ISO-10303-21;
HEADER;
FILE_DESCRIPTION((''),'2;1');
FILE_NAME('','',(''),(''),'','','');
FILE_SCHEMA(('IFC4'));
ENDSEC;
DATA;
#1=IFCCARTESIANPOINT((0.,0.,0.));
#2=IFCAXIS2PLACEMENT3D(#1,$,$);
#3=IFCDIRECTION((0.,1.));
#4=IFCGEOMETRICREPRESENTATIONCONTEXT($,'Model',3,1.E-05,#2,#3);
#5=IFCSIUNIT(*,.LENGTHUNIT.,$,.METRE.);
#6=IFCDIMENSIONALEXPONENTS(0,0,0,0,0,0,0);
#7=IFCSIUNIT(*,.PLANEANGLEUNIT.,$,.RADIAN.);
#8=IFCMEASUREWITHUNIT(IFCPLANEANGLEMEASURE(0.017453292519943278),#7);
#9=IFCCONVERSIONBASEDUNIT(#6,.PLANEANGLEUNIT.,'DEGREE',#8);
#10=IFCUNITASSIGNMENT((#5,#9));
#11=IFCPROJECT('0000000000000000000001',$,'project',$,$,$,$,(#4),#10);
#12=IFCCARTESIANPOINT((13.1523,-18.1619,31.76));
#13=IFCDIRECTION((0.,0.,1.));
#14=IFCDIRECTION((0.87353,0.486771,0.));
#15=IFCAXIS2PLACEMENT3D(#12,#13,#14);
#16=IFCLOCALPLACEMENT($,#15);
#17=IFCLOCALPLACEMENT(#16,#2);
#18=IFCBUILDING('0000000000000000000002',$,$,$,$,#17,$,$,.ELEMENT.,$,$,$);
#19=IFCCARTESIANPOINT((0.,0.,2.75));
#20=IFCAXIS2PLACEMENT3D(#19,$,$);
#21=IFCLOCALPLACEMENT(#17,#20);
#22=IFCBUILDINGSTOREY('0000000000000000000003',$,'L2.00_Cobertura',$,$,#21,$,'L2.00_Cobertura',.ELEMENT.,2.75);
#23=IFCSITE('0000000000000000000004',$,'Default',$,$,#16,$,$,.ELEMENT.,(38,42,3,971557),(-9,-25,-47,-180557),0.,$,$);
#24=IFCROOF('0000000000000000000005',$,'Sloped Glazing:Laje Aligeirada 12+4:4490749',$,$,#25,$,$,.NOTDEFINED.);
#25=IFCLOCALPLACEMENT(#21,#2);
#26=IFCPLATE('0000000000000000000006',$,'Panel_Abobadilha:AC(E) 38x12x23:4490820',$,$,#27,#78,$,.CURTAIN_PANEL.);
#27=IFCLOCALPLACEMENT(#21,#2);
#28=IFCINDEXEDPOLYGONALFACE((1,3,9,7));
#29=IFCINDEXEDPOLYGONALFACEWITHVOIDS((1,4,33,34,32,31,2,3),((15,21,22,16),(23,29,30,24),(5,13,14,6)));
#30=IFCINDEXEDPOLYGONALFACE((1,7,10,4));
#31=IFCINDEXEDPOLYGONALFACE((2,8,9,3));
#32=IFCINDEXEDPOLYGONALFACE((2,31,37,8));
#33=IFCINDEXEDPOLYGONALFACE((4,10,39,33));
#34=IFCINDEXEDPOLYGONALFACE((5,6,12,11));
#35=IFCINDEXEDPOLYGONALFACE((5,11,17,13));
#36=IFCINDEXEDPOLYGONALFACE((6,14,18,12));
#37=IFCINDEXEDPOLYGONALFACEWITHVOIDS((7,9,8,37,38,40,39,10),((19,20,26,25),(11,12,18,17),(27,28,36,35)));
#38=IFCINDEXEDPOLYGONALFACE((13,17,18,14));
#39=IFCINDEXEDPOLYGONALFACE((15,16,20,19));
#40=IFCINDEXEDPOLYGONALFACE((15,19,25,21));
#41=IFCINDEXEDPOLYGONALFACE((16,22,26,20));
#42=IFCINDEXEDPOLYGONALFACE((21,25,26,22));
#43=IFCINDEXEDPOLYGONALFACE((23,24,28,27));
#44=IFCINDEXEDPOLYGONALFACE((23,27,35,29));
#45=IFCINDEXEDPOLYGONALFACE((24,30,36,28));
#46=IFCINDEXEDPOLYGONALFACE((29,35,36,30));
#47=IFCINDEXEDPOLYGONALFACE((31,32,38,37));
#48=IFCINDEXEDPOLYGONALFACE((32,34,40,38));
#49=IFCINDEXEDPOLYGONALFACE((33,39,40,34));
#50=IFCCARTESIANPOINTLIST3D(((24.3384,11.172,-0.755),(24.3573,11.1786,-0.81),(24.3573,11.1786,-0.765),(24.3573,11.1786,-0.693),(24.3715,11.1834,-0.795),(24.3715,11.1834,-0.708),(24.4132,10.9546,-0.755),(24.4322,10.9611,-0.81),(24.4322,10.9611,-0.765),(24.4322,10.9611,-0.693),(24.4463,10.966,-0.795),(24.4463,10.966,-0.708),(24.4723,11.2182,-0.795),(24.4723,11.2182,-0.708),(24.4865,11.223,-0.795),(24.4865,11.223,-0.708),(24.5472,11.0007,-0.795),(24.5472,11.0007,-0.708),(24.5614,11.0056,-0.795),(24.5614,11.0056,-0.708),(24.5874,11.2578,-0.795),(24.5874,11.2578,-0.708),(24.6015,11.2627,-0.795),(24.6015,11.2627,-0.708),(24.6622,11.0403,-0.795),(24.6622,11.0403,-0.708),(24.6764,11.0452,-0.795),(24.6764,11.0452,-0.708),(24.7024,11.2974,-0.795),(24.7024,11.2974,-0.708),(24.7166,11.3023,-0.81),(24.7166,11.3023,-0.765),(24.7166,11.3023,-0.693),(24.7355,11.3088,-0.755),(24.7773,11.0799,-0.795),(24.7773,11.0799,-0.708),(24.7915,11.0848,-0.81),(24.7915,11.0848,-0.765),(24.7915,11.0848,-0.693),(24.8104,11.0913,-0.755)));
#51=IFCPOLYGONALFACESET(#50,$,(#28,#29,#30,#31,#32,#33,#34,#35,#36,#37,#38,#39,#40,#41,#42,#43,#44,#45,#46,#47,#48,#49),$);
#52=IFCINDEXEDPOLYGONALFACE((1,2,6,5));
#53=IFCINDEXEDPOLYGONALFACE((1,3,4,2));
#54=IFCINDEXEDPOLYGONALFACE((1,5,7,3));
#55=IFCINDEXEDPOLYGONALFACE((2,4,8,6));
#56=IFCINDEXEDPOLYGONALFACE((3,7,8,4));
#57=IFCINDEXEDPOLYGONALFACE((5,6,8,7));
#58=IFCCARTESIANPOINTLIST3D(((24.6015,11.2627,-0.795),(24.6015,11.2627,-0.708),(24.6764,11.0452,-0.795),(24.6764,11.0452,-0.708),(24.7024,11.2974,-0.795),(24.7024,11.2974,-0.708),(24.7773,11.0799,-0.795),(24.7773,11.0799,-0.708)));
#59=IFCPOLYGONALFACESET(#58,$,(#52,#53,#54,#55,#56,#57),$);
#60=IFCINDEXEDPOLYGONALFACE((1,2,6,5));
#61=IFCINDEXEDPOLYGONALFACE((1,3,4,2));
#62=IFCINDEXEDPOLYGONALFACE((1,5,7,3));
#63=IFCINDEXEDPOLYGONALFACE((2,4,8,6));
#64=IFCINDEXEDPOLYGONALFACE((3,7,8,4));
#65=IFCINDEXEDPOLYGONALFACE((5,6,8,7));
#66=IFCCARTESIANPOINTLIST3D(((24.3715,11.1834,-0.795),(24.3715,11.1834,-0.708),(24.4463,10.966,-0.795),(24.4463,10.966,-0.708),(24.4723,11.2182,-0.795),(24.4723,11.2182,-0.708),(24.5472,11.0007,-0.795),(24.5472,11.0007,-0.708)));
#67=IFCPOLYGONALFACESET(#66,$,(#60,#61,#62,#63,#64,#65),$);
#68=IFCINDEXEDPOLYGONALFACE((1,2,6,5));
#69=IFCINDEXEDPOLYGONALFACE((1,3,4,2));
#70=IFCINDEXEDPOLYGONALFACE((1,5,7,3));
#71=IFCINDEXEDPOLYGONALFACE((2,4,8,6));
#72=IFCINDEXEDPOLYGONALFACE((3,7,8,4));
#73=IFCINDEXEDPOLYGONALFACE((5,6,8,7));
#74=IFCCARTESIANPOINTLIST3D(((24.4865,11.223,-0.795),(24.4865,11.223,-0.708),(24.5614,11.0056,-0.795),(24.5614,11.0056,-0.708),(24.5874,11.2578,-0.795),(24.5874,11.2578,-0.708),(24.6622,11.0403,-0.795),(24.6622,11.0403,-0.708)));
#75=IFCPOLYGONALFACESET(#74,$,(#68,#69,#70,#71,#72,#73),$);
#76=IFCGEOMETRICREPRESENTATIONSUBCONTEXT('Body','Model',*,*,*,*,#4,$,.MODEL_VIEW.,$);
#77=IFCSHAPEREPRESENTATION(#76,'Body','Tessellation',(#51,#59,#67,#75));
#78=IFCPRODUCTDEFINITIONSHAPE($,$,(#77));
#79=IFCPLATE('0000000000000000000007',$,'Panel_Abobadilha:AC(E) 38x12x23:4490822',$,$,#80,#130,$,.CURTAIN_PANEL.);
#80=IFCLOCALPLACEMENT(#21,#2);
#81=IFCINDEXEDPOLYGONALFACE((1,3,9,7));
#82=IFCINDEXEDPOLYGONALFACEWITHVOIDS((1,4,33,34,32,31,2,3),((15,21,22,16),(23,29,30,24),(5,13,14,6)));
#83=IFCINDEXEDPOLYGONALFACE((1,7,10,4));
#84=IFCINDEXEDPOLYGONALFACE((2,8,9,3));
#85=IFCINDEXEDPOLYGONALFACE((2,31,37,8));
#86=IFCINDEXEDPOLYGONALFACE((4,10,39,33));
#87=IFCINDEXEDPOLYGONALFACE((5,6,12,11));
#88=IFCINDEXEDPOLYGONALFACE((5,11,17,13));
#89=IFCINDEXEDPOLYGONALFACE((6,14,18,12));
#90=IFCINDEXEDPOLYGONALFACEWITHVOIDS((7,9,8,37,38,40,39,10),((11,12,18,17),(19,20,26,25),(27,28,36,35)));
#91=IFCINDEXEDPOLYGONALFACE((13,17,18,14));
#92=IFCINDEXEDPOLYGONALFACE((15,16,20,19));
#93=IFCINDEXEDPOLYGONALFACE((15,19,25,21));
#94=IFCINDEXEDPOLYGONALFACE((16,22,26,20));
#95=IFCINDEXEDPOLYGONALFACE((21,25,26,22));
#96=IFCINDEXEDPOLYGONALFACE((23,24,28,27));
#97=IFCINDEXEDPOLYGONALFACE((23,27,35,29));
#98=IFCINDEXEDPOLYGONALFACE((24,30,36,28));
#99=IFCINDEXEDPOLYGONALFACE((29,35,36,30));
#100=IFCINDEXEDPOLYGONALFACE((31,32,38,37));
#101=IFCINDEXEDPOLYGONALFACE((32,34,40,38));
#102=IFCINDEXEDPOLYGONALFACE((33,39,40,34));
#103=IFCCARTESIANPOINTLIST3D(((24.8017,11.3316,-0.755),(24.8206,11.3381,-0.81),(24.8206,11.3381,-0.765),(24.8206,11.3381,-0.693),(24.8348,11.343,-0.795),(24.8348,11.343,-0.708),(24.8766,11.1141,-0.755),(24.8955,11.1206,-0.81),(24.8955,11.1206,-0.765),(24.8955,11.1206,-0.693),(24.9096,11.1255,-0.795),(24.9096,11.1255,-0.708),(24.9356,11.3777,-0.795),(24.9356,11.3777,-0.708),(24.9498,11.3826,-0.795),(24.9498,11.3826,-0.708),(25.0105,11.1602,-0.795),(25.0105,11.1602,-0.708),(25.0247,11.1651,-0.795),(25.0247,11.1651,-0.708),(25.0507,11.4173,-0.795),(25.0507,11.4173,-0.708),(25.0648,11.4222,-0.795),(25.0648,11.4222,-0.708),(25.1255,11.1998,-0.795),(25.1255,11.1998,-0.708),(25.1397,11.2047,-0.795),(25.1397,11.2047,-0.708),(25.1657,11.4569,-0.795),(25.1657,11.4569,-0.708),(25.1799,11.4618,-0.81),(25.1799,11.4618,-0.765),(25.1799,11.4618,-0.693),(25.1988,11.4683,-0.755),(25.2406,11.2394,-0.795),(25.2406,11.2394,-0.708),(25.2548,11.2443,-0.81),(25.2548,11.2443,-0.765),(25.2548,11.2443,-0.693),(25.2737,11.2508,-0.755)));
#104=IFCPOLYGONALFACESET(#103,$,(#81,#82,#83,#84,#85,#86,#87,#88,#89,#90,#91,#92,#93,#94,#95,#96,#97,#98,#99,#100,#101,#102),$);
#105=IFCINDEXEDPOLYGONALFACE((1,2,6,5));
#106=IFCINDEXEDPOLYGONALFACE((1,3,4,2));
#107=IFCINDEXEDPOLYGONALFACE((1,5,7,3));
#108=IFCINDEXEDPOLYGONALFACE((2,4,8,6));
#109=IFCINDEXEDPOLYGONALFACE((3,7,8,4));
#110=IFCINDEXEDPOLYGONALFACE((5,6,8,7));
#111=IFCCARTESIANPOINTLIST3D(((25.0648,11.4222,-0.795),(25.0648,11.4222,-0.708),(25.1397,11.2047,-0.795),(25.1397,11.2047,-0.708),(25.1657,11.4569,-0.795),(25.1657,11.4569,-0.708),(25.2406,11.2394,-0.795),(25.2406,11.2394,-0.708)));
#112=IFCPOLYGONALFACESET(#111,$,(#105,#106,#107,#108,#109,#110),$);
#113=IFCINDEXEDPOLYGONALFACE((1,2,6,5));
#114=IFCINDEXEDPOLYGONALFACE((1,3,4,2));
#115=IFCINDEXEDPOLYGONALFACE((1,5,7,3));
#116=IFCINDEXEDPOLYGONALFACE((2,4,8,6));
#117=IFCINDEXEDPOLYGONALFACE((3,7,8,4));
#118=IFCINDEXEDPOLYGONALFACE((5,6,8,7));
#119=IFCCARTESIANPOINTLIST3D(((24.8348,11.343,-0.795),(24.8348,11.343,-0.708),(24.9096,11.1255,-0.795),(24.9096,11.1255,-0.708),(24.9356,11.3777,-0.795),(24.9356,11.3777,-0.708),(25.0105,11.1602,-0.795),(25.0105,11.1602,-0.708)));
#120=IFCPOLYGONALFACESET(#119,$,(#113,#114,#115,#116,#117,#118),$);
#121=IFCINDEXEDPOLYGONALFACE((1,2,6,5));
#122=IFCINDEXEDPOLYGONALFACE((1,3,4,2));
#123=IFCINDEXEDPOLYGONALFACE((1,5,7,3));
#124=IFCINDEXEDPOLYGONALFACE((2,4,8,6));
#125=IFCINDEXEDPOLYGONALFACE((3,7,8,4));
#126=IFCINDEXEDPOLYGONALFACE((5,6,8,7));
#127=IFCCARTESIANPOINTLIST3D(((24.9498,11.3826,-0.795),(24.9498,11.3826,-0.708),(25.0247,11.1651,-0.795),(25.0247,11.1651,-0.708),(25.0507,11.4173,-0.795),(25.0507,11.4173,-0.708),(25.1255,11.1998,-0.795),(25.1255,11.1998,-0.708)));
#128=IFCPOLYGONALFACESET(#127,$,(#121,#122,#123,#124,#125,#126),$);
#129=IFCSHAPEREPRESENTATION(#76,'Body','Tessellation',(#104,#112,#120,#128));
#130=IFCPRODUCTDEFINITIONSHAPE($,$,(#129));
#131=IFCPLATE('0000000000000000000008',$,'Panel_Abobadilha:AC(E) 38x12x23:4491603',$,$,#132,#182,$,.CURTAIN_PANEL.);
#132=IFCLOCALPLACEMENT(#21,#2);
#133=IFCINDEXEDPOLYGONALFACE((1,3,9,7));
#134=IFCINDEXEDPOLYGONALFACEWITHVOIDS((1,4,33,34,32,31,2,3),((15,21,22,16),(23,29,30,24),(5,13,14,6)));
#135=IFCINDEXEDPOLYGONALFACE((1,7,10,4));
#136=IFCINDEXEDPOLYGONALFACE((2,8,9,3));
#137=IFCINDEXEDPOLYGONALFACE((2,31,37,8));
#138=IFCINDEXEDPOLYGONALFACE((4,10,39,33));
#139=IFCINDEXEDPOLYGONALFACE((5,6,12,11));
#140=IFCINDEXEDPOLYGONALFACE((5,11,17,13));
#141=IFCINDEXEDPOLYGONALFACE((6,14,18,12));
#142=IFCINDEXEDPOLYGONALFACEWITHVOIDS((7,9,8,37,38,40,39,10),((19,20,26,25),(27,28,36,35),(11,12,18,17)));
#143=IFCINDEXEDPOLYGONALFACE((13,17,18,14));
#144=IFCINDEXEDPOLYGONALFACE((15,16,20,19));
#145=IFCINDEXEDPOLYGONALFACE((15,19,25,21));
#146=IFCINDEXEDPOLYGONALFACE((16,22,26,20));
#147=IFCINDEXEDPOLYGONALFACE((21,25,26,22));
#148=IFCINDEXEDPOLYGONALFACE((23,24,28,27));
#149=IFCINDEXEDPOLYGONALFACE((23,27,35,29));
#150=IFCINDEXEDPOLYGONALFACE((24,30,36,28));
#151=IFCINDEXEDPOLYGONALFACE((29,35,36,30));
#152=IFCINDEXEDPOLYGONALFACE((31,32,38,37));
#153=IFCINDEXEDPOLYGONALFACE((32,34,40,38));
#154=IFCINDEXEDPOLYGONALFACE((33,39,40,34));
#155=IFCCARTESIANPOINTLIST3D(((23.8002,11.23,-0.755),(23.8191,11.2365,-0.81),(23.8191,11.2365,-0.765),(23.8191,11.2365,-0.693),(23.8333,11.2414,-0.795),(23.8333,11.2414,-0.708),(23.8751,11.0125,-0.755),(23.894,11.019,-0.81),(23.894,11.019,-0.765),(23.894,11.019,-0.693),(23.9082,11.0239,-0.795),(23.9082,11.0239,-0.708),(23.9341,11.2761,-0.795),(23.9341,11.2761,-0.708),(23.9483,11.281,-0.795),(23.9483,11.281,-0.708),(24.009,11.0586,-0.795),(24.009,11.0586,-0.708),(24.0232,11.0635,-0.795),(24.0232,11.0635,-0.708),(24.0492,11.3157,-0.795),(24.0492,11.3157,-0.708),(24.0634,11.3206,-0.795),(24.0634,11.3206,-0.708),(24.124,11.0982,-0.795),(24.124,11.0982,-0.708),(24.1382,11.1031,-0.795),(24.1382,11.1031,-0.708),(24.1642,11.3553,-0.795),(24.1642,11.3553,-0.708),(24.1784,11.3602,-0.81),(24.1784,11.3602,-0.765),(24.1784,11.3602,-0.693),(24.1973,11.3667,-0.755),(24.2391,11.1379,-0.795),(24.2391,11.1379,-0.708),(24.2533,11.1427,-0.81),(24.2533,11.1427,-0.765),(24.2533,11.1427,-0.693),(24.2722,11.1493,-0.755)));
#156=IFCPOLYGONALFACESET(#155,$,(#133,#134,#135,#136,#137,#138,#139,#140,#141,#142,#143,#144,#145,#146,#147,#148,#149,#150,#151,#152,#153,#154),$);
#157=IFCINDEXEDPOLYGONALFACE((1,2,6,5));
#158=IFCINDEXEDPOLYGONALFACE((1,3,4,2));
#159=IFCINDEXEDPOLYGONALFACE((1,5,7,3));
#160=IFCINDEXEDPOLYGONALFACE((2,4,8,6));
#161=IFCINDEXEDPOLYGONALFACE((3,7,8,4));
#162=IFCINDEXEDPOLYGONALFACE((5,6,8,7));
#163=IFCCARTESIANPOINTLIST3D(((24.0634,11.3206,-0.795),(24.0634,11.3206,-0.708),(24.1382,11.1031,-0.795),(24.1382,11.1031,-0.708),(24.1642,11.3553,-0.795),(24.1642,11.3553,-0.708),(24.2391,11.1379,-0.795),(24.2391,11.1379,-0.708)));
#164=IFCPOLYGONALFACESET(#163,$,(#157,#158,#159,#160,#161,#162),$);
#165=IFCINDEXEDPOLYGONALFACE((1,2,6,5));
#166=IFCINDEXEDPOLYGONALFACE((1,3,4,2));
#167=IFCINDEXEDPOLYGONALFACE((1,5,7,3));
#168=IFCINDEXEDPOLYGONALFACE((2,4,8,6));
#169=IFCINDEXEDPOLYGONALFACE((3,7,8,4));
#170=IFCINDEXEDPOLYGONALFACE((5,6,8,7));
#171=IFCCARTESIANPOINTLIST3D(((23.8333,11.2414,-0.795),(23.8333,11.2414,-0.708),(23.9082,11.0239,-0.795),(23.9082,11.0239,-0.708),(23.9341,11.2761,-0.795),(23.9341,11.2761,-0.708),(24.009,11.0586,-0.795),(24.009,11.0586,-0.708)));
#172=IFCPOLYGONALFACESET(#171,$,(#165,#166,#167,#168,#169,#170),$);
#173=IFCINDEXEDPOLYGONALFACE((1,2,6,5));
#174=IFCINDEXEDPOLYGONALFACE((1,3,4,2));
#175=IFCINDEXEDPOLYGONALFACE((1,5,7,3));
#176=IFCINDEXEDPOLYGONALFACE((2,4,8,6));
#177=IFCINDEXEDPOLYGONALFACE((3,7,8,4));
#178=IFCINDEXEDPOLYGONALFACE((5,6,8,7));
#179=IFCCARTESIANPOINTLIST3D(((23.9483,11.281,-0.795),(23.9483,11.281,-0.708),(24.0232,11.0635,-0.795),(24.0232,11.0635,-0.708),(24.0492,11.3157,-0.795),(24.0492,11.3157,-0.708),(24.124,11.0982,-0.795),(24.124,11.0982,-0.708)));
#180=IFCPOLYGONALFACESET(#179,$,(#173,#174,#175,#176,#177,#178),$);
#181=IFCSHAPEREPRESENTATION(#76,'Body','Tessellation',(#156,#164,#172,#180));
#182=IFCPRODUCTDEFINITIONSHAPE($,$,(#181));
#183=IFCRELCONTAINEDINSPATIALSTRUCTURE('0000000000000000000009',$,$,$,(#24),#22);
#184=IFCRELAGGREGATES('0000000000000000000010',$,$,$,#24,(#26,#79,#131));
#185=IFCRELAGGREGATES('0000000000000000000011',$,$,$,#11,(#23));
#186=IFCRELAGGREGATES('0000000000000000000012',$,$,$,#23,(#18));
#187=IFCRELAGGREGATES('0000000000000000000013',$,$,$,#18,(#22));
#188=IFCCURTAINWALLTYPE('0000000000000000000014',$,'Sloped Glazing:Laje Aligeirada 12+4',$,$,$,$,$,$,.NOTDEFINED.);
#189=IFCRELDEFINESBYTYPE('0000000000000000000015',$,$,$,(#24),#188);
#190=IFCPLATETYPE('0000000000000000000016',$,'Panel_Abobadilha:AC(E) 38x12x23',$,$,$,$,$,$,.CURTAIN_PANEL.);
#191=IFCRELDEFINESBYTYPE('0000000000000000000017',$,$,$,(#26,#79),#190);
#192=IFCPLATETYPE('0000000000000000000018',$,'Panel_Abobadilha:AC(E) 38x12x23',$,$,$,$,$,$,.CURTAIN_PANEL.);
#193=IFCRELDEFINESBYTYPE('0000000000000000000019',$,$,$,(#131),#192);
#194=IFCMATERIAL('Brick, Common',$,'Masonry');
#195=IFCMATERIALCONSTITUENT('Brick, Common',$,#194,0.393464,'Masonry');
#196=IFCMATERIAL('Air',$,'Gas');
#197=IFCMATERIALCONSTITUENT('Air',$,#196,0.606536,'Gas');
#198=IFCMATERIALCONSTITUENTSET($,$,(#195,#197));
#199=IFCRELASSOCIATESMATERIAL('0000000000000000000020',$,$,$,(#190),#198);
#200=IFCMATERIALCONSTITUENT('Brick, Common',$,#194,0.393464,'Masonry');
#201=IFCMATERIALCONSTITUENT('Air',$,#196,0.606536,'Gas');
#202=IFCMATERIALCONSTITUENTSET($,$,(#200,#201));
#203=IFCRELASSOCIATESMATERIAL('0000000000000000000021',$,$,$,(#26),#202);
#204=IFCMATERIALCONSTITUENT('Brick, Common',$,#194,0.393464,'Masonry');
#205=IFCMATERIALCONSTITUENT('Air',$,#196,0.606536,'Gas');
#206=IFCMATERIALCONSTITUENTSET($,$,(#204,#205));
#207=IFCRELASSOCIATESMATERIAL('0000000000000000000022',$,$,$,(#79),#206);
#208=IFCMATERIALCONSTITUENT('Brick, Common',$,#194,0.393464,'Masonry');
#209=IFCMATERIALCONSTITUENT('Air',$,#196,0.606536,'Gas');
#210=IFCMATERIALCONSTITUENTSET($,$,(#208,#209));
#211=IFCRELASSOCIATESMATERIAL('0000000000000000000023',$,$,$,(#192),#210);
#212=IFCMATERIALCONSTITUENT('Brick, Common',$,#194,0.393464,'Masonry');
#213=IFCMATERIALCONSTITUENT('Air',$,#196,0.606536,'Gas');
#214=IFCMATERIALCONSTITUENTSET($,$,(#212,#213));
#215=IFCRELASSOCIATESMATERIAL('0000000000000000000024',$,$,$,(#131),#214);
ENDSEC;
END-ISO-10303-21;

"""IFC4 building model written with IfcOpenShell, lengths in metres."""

from ifc_helpers import new_model, entity, si_unit, converted_unit, direction, frame, origin, place, context, subcontext, project, spatial, indexed_curve, outline, extrude, source, transform, mapped, material, constituent, constituent_set, type_object, type_shapes, element, aggregate, save


model = new_model("IFC4")

# Units and contexts
model_context = context("Model", 3, precision=1e-05, world=origin(), true_north=direction((0.0, 1.0)))
body_context = subcontext(model_context, "Body", "Model", "MODEL_VIEW")
ifc_project = project(units=[si_unit("LENGTHUNIT", "METRE"), converted_unit("PLANEANGLEUNIT", "DEGREE", entity("IfcPlaneAngleMeasure", 0.017453292519943278), si_unit("PLANEANGLEUNIT", "RADIAN"), dimensions=[0, 0, 0, 0, 0, 0, 0])], contexts=[model_context])

# Site, building, storey
site_placement = place(None, frame((13.1523, -18.1619, 31.76), z_axis=(0.0, 0.0, 1.0), x_axis=(0.87353, 0.486771, 0.0)))
site = spatial("IfcSite", under=ifc_project, at=site_placement, Name="Default", CompositionType="ELEMENT", RefLatitude=(38, 42, 3, 971557), RefLongitude=(-9, -25, -47, -180557), RefElevation=0.0)
building_placement = place(site_placement, origin())
building = spatial("IfcBuilding", under=site, at=building_placement, CompositionType="ELEMENT")
storey_placement = place(building_placement, frame((0.0, 0.0, 2.75)))
storey = spatial("IfcBuildingStorey", under=building, at=storey_placement, Name="L2.00_Cobertura", LongName="L2.00_Cobertura", CompositionType="ELEMENT", Elevation=2.75)

# Roof, plates
curtain_wall_type = type_object("IfcCurtainWallType", Name="Sloped Glazing:Laje Aligeirada 12+4", PredefinedType="NOTDEFINED")
roof_placement = place(storey_placement, frame((0.0, 0.0, -2.75)))
roof = element("IfcRoof", 1, at=roof_placement, inside=storey, type_object=curtain_wall_type, Name="Sloped Glazing:Laje Aligeirada 12+4:4490749", PredefinedType="NOTDEFINED")
ifc_material_1 = material(Name="Brick, Common", Category="Masonry")
ifc_constituent_1 = constituent(ifc_material_1, Name="Brick, Common", Category="Masonry", fraction=0.393464)
ifc_material_2 = material(Name="Air", Category="Gas")
ifc_constituent_2 = constituent(ifc_material_2, Name="Air", Category="Gas", fraction=0.606536)
ifc_constituent_set_1 = constituent_set(constituents=[ifc_constituent_1, ifc_constituent_2])
ifc_constituent_3 = constituent(ifc_material_1, Name="Brick, Common", Category="Masonry", fraction=0.393464)
ifc_constituent_4 = constituent(ifc_material_2, Name="Air", Category="Gas", fraction=0.606536)
ifc_constituent_set_2 = constituent_set(constituents=[ifc_constituent_3, ifc_constituent_4])
plate_type_1 = type_object("IfcPlateType", Name="Panel_Abobadilha:AC(E) 38x12x23", PredefinedType="CURTAIN_PANEL", material=ifc_constituent_set_2)
shared_shape_1 = source(origin(), body_context, "Body", "SweptSolid", [
    extrude(outline(indexed_curve([(-0.19, -0.0543), (0.19, -0.0543), (0.19, -0.0093), (0.21, 0.0007), (0.19, 0.0628), (-0.19, 0.0628), (-0.21, 0.0007), (-0.19, -0.0093), (-0.19, -0.0543)], self_intersect=False), holes=[indexed_curve([(-0.0683, 0.0477), (-0.0683, -0.0393), (-0.175, -0.0393), (-0.175, 0.0477), (-0.0683, 0.0477)], self_intersect=False), indexed_curve([(0.0533, 0.0477), (0.0533, -0.0393), (-0.0533, -0.0393), (-0.0533, 0.0477), (0.0533, 0.0477)], self_intersect=False), indexed_curve([(0.175, 0.0477), (0.175, -0.0393), (0.0683, -0.0393), (0.0683, 0.0477), (0.175, 0.0477)], self_intersect=False)]), frame((0.0, 0.0543, 0.0)), (0.0, 0.0, 1.0), 0.23),
    extrude(outline(indexed_curve([(-0.0533, -0.0435), (0.0533, -0.0435), (0.0533, 0.0435), (-0.0533, 0.0435), (-0.0533, -0.0435)], self_intersect=False)), frame((0.1217, 0.0585, 0.0), z_axis=(0.0, 0.0, 1.0), x_axis=(-1.0, 0.0, 0.0)), (0.0, 0.0, 1.0), 0.23),
    extrude(outline(indexed_curve([(-0.0533, -0.0435), (0.0533, -0.0435), (0.0533, 0.0435), (-0.0533, 0.0435), (-0.0533, -0.0435)], self_intersect=False)), frame((-0.1217, 0.0585, 0.0), z_axis=(0.0, 0.0, 1.0), x_axis=(-1.0, 0.0, 0.0)), (0.0, 0.0, 1.0), 0.23),
    extrude(outline(indexed_curve([(-0.0533, -0.0435), (0.0533, -0.0435), (0.0533, 0.0435), (-0.0533, 0.0435), (-0.0533, -0.0435)], self_intersect=False)), frame((0.0, 0.0585, 0.0), z_axis=(0.0, 0.0, 1.0), x_axis=(-1.0, 0.0, 0.0)), (0.0, 0.0, 1.0), 0.23),
])
type_shapes(plate_type_1, [shared_shape_1])
plate_1_placement = place(roof_placement, frame((24.5369, 11.2404, 1.94), z_axis=(0.325568, -0.945519, 0.0), x_axis=(0.945519, 0.325568, 0.0)))
plate_1 = element("IfcPlate", 2, at=plate_1_placement, type_object=plate_type_1, material=ifc_constituent_set_1, Name="Panel_Abobadilha:AC(E) 38x12x23:4490820", PredefinedType="CURTAIN_PANEL", context=body_context, shape_type="MappedRepresentation", body=[
    mapped(shared_shape_1, transform((0.0, 0.0, 0.0), scale=1.0)),
])
ifc_constituent_5 = constituent(ifc_material_1, Name="Brick, Common", Category="Masonry", fraction=0.393464)
ifc_constituent_6 = constituent(ifc_material_2, Name="Air", Category="Gas", fraction=0.606536)
ifc_constituent_set_3 = constituent_set(constituents=[ifc_constituent_5, ifc_constituent_6])
plate_2_placement = place(roof_placement, frame((25.0002, 11.3999, 1.94), z_axis=(0.325568, -0.945519, 0.0), x_axis=(0.945519, 0.325568, 0.0)))
plate_2 = element("IfcPlate", 3, at=plate_2_placement, type_object=plate_type_1, material=ifc_constituent_set_3, Name="Panel_Abobadilha:AC(E) 38x12x23:4490822", PredefinedType="CURTAIN_PANEL", context=body_context, shape_type="MappedRepresentation", body=[
    mapped(shared_shape_1, transform((0.0, 0.0, 0.0), scale=1.0)),
])
ifc_constituent_7 = constituent(ifc_material_1, Name="Brick, Common", Category="Masonry", fraction=0.393464)
ifc_constituent_8 = constituent(ifc_material_2, Name="Air", Category="Gas", fraction=0.606536)
ifc_constituent_set_4 = constituent_set(constituents=[ifc_constituent_7, ifc_constituent_8])
ifc_constituent_9 = constituent(ifc_material_1, Name="Brick, Common", Category="Masonry", fraction=0.393464)
ifc_constituent_10 = constituent(ifc_material_2, Name="Air", Category="Gas", fraction=0.606536)
ifc_constituent_set_5 = constituent_set(constituents=[ifc_constituent_9, ifc_constituent_10])
plate_type_2 = type_object("IfcPlateType", Name="Panel_Abobadilha:AC(E) 38x12x23", PredefinedType="CURTAIN_PANEL", material=ifc_constituent_set_5)
shared_shape_2 = source(origin(), body_context, "Body", "SweptSolid", [
    extrude(outline(indexed_curve([(-0.19, -0.0543), (0.19, -0.0543), (0.19, -0.0093), (0.21, 0.0007), (0.19, 0.0628), (-0.19, 0.0628), (-0.21, 0.0007), (-0.19, -0.0093), (-0.19, -0.0543)], self_intersect=False), holes=[indexed_curve([(-0.0683, 0.0477), (-0.0683, -0.0393), (-0.175, -0.0393), (-0.175, 0.0477), (-0.0683, 0.0477)], self_intersect=False), indexed_curve([(0.0533, 0.0477), (0.0533, -0.0393), (-0.0533, -0.0393), (-0.0533, 0.0477), (0.0533, 0.0477)], self_intersect=False), indexed_curve([(0.175, 0.0477), (0.175, -0.0393), (0.0683, -0.0393), (0.0683, 0.0477), (0.175, 0.0477)], self_intersect=False)]), frame((0.0, 0.0543, 0.0)), (0.0, 0.0, 1.0), 0.23),
    extrude(outline(indexed_curve([(-0.0533, -0.0435), (0.0533, -0.0435), (0.0533, 0.0435), (-0.0533, 0.0435), (-0.0533, -0.0435)], self_intersect=False)), frame((0.1217, 0.0585, 0.0), z_axis=(0.0, 0.0, 1.0), x_axis=(-1.0, 0.0, 0.0)), (0.0, 0.0, 1.0), 0.23),
    extrude(outline(indexed_curve([(-0.0533, -0.0435), (0.0533, -0.0435), (0.0533, 0.0435), (-0.0533, 0.0435), (-0.0533, -0.0435)], self_intersect=False)), frame((-0.1217, 0.0585, 0.0), z_axis=(0.0, 0.0, 1.0), x_axis=(-1.0, 0.0, 0.0)), (0.0, 0.0, 1.0), 0.23),
    extrude(outline(indexed_curve([(-0.0533, -0.0435), (0.0533, -0.0435), (0.0533, 0.0435), (-0.0533, 0.0435), (-0.0533, -0.0435)], self_intersect=False)), frame((0.0, 0.0585, 0.0), z_axis=(0.0, 0.0, 1.0), x_axis=(-1.0, 0.0, 0.0)), (0.0, 0.0, 1.0), 0.23),
])
type_shapes(plate_type_2, [shared_shape_2])
plate_3_placement = place(roof_placement, frame((23.9987, 11.2984, 1.94), z_axis=(0.325568, -0.945519, 0.0), x_axis=(0.945519, 0.325568, 0.0)))
plate_3 = element("IfcPlate", 4, at=plate_3_placement, type_object=plate_type_2, material=ifc_constituent_set_4, Name="Panel_Abobadilha:AC(E) 38x12x23:4491603", PredefinedType="CURTAIN_PANEL", context=body_context, shape_type="MappedRepresentation", body=[
    mapped(shared_shape_2, transform((0.0, 0.0, 0.0), scale=1.0)),
])
aggregate(roof, [plate_1, plate_2, plate_3])

save(model, "model.ifc")
